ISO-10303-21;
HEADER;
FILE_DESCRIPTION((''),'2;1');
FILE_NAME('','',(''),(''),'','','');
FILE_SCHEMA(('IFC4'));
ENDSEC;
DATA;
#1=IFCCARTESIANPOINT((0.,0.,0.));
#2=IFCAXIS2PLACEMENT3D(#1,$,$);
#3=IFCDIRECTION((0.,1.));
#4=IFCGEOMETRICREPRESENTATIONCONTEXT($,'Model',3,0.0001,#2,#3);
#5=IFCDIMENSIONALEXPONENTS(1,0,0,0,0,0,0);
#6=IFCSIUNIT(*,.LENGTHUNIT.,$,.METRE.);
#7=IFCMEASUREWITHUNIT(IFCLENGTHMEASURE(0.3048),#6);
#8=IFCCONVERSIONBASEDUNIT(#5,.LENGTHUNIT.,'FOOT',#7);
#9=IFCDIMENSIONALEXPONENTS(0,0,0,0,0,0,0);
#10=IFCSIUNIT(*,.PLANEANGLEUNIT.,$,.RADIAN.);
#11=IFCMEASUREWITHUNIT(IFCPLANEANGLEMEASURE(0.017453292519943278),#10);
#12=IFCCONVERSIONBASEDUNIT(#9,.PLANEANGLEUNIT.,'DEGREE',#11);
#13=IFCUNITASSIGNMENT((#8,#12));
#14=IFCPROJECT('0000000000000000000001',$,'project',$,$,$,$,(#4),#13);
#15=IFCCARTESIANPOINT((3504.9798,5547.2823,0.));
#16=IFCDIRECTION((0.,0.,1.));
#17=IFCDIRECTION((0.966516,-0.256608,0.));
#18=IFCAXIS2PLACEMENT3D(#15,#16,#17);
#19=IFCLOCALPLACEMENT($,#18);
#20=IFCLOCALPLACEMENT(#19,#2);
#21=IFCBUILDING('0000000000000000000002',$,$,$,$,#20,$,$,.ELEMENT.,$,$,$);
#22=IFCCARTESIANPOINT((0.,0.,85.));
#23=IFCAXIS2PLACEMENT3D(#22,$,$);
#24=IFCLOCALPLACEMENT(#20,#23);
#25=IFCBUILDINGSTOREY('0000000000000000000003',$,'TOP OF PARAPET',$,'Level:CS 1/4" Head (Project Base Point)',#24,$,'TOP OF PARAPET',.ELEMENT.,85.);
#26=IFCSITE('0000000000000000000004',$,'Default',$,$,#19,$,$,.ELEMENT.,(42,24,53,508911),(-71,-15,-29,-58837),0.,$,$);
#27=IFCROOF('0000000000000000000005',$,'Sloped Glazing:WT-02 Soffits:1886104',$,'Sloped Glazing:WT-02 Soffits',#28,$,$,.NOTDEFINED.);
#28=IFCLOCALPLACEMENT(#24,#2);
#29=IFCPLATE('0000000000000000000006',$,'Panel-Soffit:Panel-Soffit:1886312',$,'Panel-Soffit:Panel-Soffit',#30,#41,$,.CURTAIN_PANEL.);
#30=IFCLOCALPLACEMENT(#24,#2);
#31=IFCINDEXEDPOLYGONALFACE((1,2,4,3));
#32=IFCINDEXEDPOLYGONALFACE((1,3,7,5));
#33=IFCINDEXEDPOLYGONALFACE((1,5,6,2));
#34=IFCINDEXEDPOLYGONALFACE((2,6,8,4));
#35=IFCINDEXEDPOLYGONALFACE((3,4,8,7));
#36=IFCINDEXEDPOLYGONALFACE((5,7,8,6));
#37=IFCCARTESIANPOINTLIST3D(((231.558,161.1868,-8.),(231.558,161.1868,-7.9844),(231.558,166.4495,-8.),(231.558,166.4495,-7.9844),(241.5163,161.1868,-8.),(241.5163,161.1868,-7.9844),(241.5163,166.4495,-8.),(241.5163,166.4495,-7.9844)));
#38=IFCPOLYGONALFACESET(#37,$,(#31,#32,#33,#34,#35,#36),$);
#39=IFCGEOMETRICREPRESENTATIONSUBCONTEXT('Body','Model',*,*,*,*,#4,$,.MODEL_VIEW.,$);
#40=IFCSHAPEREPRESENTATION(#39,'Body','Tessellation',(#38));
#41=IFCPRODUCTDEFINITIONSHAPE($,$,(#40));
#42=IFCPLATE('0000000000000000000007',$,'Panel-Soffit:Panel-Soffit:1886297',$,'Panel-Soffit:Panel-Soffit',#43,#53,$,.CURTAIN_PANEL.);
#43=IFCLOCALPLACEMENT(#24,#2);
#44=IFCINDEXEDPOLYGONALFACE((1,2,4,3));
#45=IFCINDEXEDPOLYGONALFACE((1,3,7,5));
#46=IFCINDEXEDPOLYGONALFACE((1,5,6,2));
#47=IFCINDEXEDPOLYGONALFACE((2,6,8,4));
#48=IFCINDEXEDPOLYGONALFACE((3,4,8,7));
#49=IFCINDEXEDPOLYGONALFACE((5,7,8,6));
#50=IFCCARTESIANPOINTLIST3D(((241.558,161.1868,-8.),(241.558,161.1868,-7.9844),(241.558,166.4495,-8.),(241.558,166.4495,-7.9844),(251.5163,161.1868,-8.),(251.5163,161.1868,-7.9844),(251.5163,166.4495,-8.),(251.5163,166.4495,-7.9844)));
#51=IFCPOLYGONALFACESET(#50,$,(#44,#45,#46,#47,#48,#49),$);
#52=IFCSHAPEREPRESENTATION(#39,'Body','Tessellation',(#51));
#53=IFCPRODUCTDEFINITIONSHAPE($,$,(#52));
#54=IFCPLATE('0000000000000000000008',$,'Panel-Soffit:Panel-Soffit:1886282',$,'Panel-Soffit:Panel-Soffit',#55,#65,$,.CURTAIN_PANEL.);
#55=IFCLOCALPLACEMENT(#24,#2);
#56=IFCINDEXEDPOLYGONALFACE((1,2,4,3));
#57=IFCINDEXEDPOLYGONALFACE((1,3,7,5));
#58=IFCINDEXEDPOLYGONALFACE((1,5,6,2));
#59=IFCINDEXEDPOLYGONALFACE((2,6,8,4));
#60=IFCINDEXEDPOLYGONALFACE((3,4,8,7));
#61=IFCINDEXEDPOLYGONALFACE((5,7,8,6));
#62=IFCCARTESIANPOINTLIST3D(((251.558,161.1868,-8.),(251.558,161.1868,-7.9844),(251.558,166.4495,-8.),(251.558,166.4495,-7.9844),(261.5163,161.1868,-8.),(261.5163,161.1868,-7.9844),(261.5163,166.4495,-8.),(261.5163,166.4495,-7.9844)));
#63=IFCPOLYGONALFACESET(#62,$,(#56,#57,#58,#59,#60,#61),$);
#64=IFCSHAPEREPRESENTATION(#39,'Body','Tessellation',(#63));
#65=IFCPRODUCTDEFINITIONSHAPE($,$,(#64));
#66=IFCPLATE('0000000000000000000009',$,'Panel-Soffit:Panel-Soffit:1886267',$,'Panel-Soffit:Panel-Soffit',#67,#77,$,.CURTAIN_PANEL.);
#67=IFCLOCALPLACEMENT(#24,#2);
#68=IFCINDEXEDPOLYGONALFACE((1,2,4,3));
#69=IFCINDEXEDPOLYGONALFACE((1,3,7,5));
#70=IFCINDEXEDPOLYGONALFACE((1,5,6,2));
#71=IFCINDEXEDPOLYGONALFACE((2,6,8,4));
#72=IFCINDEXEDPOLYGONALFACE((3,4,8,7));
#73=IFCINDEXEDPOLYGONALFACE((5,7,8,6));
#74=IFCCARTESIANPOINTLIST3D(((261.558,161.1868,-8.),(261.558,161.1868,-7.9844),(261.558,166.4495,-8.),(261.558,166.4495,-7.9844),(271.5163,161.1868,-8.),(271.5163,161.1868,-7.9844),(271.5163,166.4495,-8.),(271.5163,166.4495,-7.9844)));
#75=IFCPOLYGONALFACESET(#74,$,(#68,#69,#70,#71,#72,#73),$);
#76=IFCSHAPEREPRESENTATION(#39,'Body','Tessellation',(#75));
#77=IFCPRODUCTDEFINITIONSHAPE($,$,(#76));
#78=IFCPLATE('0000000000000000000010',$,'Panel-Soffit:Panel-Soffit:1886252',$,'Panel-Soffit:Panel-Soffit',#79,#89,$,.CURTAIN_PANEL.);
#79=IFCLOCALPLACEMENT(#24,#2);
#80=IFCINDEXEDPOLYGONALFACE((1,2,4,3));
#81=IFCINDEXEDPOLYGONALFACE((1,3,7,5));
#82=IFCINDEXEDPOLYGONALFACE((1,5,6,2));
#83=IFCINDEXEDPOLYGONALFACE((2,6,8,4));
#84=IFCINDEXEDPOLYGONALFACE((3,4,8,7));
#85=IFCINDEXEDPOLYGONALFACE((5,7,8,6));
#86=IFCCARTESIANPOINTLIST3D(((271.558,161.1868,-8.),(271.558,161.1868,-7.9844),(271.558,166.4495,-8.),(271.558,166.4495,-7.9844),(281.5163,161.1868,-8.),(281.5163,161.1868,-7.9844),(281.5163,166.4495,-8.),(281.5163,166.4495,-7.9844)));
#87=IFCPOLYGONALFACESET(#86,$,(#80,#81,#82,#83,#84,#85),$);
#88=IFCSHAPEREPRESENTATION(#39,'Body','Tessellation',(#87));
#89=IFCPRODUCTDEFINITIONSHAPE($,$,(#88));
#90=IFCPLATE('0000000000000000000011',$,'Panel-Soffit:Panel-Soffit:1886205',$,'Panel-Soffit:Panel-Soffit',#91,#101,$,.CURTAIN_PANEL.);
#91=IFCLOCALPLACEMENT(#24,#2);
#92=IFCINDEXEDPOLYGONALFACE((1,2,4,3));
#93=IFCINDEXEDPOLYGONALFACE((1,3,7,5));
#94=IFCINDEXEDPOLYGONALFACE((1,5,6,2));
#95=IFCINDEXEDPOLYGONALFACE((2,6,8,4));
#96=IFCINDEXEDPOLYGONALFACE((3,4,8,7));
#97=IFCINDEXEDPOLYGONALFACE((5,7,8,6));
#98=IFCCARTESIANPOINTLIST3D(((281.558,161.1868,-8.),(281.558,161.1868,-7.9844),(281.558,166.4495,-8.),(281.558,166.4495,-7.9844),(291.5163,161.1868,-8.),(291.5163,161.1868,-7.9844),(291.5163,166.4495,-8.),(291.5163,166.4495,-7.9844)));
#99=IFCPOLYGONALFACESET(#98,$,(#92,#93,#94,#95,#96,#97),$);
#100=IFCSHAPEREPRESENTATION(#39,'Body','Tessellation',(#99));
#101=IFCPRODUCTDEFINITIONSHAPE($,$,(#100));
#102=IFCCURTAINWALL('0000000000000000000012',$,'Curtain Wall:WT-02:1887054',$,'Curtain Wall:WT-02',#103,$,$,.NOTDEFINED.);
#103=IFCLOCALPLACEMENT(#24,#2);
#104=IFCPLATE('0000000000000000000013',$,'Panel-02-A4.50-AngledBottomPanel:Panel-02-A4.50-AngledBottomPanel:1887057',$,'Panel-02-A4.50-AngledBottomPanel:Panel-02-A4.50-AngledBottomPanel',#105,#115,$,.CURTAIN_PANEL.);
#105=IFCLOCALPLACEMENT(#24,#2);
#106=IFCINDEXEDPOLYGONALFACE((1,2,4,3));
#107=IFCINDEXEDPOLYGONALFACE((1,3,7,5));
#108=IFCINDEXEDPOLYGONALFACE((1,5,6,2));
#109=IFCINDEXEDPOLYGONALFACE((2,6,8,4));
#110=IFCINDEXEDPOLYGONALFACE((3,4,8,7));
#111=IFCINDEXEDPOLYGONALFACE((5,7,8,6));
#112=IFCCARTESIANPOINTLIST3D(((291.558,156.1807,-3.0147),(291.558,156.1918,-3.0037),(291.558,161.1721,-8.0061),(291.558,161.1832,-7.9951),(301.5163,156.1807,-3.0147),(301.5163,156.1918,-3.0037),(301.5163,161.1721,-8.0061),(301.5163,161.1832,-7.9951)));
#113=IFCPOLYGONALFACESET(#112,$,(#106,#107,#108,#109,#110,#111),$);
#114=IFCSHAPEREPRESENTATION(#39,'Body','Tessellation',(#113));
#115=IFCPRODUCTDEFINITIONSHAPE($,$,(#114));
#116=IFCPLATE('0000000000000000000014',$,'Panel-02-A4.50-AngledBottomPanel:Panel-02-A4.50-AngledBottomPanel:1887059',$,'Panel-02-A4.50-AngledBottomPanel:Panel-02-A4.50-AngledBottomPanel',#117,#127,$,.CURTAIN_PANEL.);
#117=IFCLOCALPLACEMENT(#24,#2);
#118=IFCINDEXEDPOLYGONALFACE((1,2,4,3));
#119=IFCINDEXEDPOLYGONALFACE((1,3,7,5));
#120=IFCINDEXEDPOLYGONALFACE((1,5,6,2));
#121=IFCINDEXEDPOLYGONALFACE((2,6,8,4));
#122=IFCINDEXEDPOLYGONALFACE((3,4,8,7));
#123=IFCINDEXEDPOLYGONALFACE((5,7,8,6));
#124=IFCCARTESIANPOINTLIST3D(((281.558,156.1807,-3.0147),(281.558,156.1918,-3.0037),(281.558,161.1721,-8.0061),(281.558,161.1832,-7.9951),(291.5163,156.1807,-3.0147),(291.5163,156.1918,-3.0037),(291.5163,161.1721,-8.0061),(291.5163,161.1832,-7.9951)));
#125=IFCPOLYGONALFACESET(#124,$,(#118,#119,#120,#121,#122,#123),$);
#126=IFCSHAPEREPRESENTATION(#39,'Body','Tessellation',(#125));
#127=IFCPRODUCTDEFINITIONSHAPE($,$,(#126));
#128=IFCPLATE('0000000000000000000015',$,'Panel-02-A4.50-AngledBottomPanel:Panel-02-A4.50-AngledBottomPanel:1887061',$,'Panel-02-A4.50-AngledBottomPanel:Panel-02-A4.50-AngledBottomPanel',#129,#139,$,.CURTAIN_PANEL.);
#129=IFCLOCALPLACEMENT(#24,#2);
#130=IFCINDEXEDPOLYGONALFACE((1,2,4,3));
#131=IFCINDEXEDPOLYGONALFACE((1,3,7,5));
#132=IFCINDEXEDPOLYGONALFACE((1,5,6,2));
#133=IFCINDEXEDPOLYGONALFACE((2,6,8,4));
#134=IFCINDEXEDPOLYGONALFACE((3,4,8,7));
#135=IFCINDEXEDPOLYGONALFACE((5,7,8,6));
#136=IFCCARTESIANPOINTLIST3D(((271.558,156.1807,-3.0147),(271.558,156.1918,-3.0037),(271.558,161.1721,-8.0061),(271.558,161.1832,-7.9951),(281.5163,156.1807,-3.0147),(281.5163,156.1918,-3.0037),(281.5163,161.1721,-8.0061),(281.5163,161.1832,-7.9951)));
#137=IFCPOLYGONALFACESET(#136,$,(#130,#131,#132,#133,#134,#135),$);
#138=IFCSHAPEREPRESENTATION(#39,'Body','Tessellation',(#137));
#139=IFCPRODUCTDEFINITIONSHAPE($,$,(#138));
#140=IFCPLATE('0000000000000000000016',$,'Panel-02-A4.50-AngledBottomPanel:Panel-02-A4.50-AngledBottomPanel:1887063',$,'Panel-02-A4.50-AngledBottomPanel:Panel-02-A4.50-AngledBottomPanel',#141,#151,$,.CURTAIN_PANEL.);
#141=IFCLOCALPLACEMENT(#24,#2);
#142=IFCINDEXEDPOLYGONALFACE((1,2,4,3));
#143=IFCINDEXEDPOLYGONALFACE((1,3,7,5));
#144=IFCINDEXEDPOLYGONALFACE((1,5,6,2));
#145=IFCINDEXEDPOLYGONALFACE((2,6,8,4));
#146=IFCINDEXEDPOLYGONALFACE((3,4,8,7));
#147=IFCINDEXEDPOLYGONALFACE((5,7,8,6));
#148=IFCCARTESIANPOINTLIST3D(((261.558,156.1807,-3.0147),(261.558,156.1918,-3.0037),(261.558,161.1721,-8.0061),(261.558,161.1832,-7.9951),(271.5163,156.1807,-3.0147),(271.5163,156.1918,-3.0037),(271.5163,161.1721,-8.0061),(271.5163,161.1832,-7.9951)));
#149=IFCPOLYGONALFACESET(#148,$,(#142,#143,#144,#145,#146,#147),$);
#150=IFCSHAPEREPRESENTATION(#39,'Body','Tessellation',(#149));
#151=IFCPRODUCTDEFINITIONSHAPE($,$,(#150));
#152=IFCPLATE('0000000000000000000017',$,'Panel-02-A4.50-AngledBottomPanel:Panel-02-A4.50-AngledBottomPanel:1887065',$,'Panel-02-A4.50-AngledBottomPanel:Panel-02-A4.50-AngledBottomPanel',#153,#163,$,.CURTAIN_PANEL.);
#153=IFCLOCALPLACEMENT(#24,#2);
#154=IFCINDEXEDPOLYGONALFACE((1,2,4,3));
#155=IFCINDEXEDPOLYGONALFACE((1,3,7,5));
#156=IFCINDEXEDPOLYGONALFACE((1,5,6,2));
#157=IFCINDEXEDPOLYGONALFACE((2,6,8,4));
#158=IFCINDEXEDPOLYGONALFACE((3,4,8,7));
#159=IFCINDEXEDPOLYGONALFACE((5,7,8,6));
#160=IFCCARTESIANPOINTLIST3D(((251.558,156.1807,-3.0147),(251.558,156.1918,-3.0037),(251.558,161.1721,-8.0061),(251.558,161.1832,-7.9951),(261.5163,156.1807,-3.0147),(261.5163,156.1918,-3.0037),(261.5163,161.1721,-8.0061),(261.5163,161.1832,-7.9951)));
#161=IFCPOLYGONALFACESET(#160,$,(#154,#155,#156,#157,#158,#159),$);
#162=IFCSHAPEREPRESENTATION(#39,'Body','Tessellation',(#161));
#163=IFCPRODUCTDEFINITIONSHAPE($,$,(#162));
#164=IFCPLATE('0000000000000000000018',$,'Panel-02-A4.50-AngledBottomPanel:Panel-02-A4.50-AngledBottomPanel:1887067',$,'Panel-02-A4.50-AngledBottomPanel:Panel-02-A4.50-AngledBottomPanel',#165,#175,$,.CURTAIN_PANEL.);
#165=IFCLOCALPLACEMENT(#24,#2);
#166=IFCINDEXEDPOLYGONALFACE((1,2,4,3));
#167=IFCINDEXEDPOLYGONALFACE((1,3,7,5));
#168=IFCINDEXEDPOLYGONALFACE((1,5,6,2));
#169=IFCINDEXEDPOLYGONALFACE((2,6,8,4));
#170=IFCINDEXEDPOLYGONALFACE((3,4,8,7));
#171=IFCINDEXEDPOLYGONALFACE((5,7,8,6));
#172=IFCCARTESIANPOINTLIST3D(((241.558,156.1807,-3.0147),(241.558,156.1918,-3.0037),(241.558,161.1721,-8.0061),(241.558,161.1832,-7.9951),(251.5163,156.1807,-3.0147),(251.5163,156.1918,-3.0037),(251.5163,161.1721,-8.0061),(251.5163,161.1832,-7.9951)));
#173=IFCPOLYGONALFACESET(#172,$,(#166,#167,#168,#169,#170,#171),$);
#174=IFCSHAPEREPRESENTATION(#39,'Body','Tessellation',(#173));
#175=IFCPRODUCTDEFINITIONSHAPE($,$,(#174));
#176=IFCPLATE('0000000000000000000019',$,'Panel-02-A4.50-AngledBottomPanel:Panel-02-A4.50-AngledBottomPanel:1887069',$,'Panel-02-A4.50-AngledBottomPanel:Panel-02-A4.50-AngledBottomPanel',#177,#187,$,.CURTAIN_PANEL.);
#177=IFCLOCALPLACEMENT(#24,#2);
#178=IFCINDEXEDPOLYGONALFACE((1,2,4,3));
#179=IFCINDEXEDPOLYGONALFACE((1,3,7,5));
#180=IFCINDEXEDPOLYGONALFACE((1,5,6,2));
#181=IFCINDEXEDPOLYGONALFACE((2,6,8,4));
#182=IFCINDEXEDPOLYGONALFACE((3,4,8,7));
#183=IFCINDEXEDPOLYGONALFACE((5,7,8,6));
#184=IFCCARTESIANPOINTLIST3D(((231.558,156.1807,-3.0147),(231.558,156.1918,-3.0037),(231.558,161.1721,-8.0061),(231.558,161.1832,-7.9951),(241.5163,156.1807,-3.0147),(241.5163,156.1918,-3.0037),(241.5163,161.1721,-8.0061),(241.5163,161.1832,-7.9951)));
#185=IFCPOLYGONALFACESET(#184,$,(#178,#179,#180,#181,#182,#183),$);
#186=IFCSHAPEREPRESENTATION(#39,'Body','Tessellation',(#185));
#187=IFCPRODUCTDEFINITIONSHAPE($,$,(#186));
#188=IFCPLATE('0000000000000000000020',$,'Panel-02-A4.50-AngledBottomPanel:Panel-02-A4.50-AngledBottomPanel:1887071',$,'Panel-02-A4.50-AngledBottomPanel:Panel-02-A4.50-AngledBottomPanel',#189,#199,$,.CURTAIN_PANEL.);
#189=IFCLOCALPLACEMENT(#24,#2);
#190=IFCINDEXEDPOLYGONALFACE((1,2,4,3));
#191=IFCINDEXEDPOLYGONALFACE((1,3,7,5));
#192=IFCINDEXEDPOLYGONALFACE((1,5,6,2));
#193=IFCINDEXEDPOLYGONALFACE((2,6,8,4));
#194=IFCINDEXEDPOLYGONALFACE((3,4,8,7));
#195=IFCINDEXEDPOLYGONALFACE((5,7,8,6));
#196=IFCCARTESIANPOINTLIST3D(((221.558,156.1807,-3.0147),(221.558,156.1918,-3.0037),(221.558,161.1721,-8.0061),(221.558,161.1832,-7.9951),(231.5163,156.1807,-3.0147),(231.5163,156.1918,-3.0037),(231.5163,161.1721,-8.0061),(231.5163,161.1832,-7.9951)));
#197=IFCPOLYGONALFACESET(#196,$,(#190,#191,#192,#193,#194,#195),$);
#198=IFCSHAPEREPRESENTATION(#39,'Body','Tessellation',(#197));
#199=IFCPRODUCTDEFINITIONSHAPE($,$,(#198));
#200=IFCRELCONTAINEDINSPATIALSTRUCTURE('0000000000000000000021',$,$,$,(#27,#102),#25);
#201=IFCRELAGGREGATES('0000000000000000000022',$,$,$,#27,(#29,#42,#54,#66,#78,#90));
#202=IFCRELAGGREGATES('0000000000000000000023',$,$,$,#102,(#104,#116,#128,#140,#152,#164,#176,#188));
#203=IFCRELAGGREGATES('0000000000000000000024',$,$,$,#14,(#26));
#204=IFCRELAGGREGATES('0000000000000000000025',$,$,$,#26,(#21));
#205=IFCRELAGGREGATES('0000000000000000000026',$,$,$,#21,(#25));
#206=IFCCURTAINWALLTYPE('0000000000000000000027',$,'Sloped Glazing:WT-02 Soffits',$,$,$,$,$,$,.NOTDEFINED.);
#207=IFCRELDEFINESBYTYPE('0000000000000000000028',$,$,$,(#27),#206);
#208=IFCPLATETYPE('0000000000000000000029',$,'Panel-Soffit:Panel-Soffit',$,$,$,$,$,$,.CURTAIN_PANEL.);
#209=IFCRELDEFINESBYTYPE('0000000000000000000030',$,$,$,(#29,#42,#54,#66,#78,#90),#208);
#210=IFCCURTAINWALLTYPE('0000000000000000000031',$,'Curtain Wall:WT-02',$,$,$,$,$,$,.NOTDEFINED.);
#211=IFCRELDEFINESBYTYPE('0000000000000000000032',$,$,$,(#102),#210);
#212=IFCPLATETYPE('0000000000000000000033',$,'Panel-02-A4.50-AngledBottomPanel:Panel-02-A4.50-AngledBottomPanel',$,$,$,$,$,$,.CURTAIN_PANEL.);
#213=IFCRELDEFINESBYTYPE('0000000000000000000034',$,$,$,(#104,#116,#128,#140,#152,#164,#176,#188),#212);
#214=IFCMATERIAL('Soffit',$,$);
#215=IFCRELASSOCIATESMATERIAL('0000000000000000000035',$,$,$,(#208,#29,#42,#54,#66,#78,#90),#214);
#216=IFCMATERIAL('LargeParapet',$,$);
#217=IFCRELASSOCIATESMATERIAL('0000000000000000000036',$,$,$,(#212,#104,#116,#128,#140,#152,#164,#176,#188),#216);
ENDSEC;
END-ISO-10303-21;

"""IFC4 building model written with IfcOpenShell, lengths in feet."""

from ifc_helpers import new_model, entity, si_unit, converted_unit, direction, frame, origin, place, context, subcontext, project, spatial, indexed_curve, outline, extrude, source, transform, mapped, material, type_object, type_shapes, element, aggregate, save


model = new_model("IFC4")

# Units and contexts
model_context = context("Model", 3, precision=0.0001, world=origin(), true_north=direction((0.0, 1.0)))
body_context = subcontext(model_context, "Body", "Model", "MODEL_VIEW")
ifc_project = project(units=[converted_unit("LENGTHUNIT", "FOOT", entity("IfcLengthMeasure", 0.3048), si_unit("LENGTHUNIT", "METRE"), dimensions=[1, 0, 0, 0, 0, 0, 0]), converted_unit("PLANEANGLEUNIT", "DEGREE", entity("IfcPlaneAngleMeasure", 0.017453292519943278), si_unit("PLANEANGLEUNIT", "RADIAN"), dimensions=[0, 0, 0, 0, 0, 0, 0])], contexts=[model_context])

# Site, building, storey
site_placement = place(None, frame((3504.9798, 5547.2823, 0.0), z_axis=(0.0, 0.0, 1.0), x_axis=(0.966516, -0.256608, 0.0)))
site = spatial("IfcSite", under=ifc_project, at=site_placement, Name="Default", CompositionType="ELEMENT", RefLatitude=(42, 24, 53, 508911), RefLongitude=(-71, -15, -29, -58837), RefElevation=0.0)
building_placement = place(site_placement, origin())
building = spatial("IfcBuilding", under=site, at=building_placement, CompositionType="ELEMENT")
storey_placement = place(building_placement, frame((0.0, 0.0, 85.0)))
storey = spatial("IfcBuildingStorey", under=building, at=storey_placement, Name="TOP OF PARAPET", ObjectType="Level:CS 1/4\" Head (Project Base Point)", LongName="TOP OF PARAPET", CompositionType="ELEMENT", Elevation=85.0)

# Shared definitions
curtain_wall_type_1 = type_object("IfcCurtainWallType", Name="Curtain Wall:WT-02", PredefinedType="NOTDEFINED")
ifc_material_1 = material(Name="LargeParapet")

# Roof, plates
curtain_wall_type_2 = type_object("IfcCurtainWallType", Name="Sloped Glazing:WT-02 Soffits", PredefinedType="NOTDEFINED")
roof_placement = place(storey_placement, frame((0.0, 0.0, -85.0)))
roof = element("IfcRoof", 1, at=roof_placement, inside=storey, type_object=curtain_wall_type_2, Name="Sloped Glazing:WT-02 Soffits:1886104", ObjectType="Sloped Glazing:WT-02 Soffits", PredefinedType="NOTDEFINED")
ifc_material_2 = material(Name="Soffit")
plate_type_1 = type_object("IfcPlateType", Name="Panel-Soffit:Panel-Soffit", PredefinedType="CURTAIN_PANEL", material=ifc_material_2)
shared_shape_1 = source(origin(), body_context, "Body", "SweptSolid", [
    extrude(outline(indexed_curve([(-0.0078, -4.9792), (0.0078, -4.9792), (0.0078, 4.9792), (-0.0078, 4.9792), (-0.0078, -4.9792)], self_intersect=False)), frame((0.0, -0.0078, 0.0208), z_axis=(0.0, 0.0, 1.0), x_axis=(0.0, -1.0, 0.0)), (0.0, 0.0, 1.0), 5.2626),
])
type_shapes(plate_type_1, [shared_shape_1])
plate_1_placement = place(roof_placement, frame((236.5372, 161.166, 77.0), z_axis=(0.0, 1.0, 0.0), x_axis=(1.0, 0.0, 0.0)))
plate_1 = element("IfcPlate", 2, at=plate_1_placement, type_object=plate_type_1, material=ifc_material_2, Name="Panel-Soffit:Panel-Soffit:1886312", ObjectType="Panel-Soffit:Panel-Soffit", PredefinedType="CURTAIN_PANEL", context=body_context, shape_type="MappedRepresentation", body=[
    mapped(shared_shape_1, transform((0.0, 0.0, 0.0), scale=1.0)),
])
plate_2_placement = place(roof_placement, frame((246.5372, 161.166, 77.0), z_axis=(0.0, 1.0, 0.0), x_axis=(1.0, 0.0, 0.0)))
plate_2 = element("IfcPlate", 3, at=plate_2_placement, type_object=plate_type_1, material=ifc_material_2, Name="Panel-Soffit:Panel-Soffit:1886297", ObjectType="Panel-Soffit:Panel-Soffit", PredefinedType="CURTAIN_PANEL", context=body_context, shape_type="MappedRepresentation", body=[
    mapped(shared_shape_1, transform((0.0, 0.0, 0.0), scale=1.0)),
])
plate_3_placement = place(roof_placement, frame((256.5372, 161.166, 77.0), z_axis=(0.0, 1.0, 0.0), x_axis=(1.0, 0.0, 0.0)))
plate_3 = element("IfcPlate", 4, at=plate_3_placement, type_object=plate_type_1, material=ifc_material_2, Name="Panel-Soffit:Panel-Soffit:1886282", ObjectType="Panel-Soffit:Panel-Soffit", PredefinedType="CURTAIN_PANEL", context=body_context, shape_type="MappedRepresentation", body=[
    mapped(shared_shape_1, transform((0.0, 0.0, 0.0), scale=1.0)),
])
plate_4_placement = place(roof_placement, frame((266.5372, 161.166, 77.0), z_axis=(0.0, 1.0, 0.0), x_axis=(1.0, 0.0, 0.0)))
plate_4 = element("IfcPlate", 5, at=plate_4_placement, type_object=plate_type_1, material=ifc_material_2, Name="Panel-Soffit:Panel-Soffit:1886267", ObjectType="Panel-Soffit:Panel-Soffit", PredefinedType="CURTAIN_PANEL", context=body_context, shape_type="MappedRepresentation", body=[
    mapped(shared_shape_1, transform((0.0, 0.0, 0.0), scale=1.0)),
])
plate_5_placement = place(roof_placement, frame((276.5372, 161.166, 77.0), z_axis=(0.0, 1.0, 0.0), x_axis=(1.0, 0.0, 0.0)))
plate_5 = element("IfcPlate", 6, at=plate_5_placement, type_object=plate_type_1, material=ifc_material_2, Name="Panel-Soffit:Panel-Soffit:1886252", ObjectType="Panel-Soffit:Panel-Soffit", PredefinedType="CURTAIN_PANEL", context=body_context, shape_type="MappedRepresentation", body=[
    mapped(shared_shape_1, transform((0.0, 0.0, 0.0), scale=1.0)),
])
plate_6_placement = place(roof_placement, frame((286.5372, 161.166, 77.0), z_axis=(0.0, 1.0, 0.0), x_axis=(1.0, 0.0, 0.0)))
plate_6 = element("IfcPlate", 7, at=plate_6_placement, type_object=plate_type_1, material=ifc_material_2, Name="Panel-Soffit:Panel-Soffit:1886205", ObjectType="Panel-Soffit:Panel-Soffit", PredefinedType="CURTAIN_PANEL", context=body_context, shape_type="MappedRepresentation", body=[
    mapped(shared_shape_1, transform((0.0, 0.0, 0.0), scale=1.0)),
])
aggregate(roof, [plate_1, plate_2, plate_3, plate_4, plate_5, plate_6])

# Curtain wall, plates
curtain_wall_1_placement = place(storey_placement, frame((0.0, 0.0, -85.0)))
curtain_wall_1 = element("IfcCurtainWall", 8, at=curtain_wall_1_placement, inside=storey, type_object=curtain_wall_type_1, Name="Curtain Wall:WT-02:1887054", ObjectType="Curtain Wall:WT-02", PredefinedType="NOTDEFINED")
plate_type_2 = type_object("IfcPlateType", Name="Panel-02-A4.50-AngledBottomPanel:Panel-02-A4.50-AngledBottomPanel", PredefinedType="CURTAIN_PANEL", material=ifc_material_1)
shared_shape_2 = source(origin(), body_context, "Body", "SweptSolid", [
    extrude(outline(indexed_curve([(-0.0078, -4.9792), (0.0078, -4.9792), (0.0078, 4.9792), (-0.0078, 4.9792), (-0.0078, -4.9792)], self_intersect=False)), frame((0.0, -0.0078, 0.0208), z_axis=(0.0, 0.0, 1.0), x_axis=(0.0, -1.0, 0.0)), (0.0, 0.0, 1.0), 7.0589),
])
type_shapes(plate_type_2, [shared_shape_2])
plate_7_placement = place(curtain_wall_1_placement, frame((296.5372, 161.1868, 76.9792), z_axis=(0.0, -0.707107, 0.707107), x_axis=(-1.0, 0.0, 0.0)))
plate_7 = element("IfcPlate", 9, at=plate_7_placement, type_object=plate_type_2, material=ifc_material_1, Name="Panel-02-A4.50-AngledBottomPanel:Panel-02-A4.50-AngledBottomPanel:1887057", ObjectType="Panel-02-A4.50-AngledBottomPanel:Panel-02-A4.50-AngledBottomPanel", PredefinedType="CURTAIN_PANEL", context=body_context, shape_type="MappedRepresentation", body=[
    mapped(shared_shape_2, transform((0.0, 0.0, 0.0), scale=1.0)),
])
plate_8_placement = place(curtain_wall_1_placement, frame((286.5372, 161.1868, 76.9792), z_axis=(0.0, -0.707107, 0.707107), x_axis=(-1.0, 0.0, 0.0)))
plate_8 = element("IfcPlate", 10, at=plate_8_placement, type_object=plate_type_2, material=ifc_material_1, Name="Panel-02-A4.50-AngledBottomPanel:Panel-02-A4.50-AngledBottomPanel:1887059", ObjectType="Panel-02-A4.50-AngledBottomPanel:Panel-02-A4.50-AngledBottomPanel", PredefinedType="CURTAIN_PANEL", context=body_context, shape_type="MappedRepresentation", body=[
    mapped(shared_shape_2, transform((0.0, 0.0, 0.0), scale=1.0)),
])
plate_9_placement = place(curtain_wall_1_placement, frame((276.5372, 161.1868, 76.9792), z_axis=(0.0, -0.707107, 0.707107), x_axis=(-1.0, 0.0, 0.0)))
plate_9 = element("IfcPlate", 11, at=plate_9_placement, type_object=plate_type_2, material=ifc_material_1, Name="Panel-02-A4.50-AngledBottomPanel:Panel-02-A4.50-AngledBottomPanel:1887061", ObjectType="Panel-02-A4.50-AngledBottomPanel:Panel-02-A4.50-AngledBottomPanel", PredefinedType="CURTAIN_PANEL", context=body_context, shape_type="MappedRepresentation", body=[
    mapped(shared_shape_2, transform((0.0, 0.0, 0.0), scale=1.0)),
])
plate_10_placement = place(curtain_wall_1_placement, frame((266.5372, 161.1868, 76.9792), z_axis=(0.0, -0.707107, 0.707107), x_axis=(-1.0, 0.0, 0.0)))
plate_10 = element("IfcPlate", 12, at=plate_10_placement, type_object=plate_type_2, material=ifc_material_1, Name="Panel-02-A4.50-AngledBottomPanel:Panel-02-A4.50-AngledBottomPanel:1887063", ObjectType="Panel-02-A4.50-AngledBottomPanel:Panel-02-A4.50-AngledBottomPanel", PredefinedType="CURTAIN_PANEL", context=body_context, shape_type="MappedRepresentation", body=[
    mapped(shared_shape_2, transform((0.0, 0.0, 0.0), scale=1.0)),
])
plate_11_placement = place(curtain_wall_1_placement, frame((256.5372, 161.1868, 76.9792), z_axis=(0.0, -0.707107, 0.707107), x_axis=(-1.0, 0.0, 0.0)))
plate_11 = element("IfcPlate", 13, at=plate_11_placement, type_object=plate_type_2, material=ifc_material_1, Name="Panel-02-A4.50-AngledBottomPanel:Panel-02-A4.50-AngledBottomPanel:1887065", ObjectType="Panel-02-A4.50-AngledBottomPanel:Panel-02-A4.50-AngledBottomPanel", PredefinedType="CURTAIN_PANEL", context=body_context, shape_type="MappedRepresentation", body=[
    mapped(shared_shape_2, transform((0.0, 0.0, 0.0), scale=1.0)),
])
plate_12_placement = place(curtain_wall_1_placement, frame((246.5372, 161.1868, 76.9792), z_axis=(0.0, -0.707107, 0.707107), x_axis=(-1.0, 0.0, 0.0)))
plate_12 = element("IfcPlate", 14, at=plate_12_placement, type_object=plate_type_2, material=ifc_material_1, Name="Panel-02-A4.50-AngledBottomPanel:Panel-02-A4.50-AngledBottomPanel:1887067", ObjectType="Panel-02-A4.50-AngledBottomPanel:Panel-02-A4.50-AngledBottomPanel", PredefinedType="CURTAIN_PANEL", context=body_context, shape_type="MappedRepresentation", body=[
    mapped(shared_shape_2, transform((0.0, 0.0, 0.0), scale=1.0)),
])
plate_13_placement = place(curtain_wall_1_placement, frame((236.5372, 161.1868, 76.9792), z_axis=(0.0, -0.707107, 0.707107), x_axis=(-1.0, 0.0, 0.0)))
plate_13 = element("IfcPlate", 15, at=plate_13_placement, type_object=plate_type_2, material=ifc_material_1, Name="Panel-02-A4.50-AngledBottomPanel:Panel-02-A4.50-AngledBottomPanel:1887069", ObjectType="Panel-02-A4.50-AngledBottomPanel:Panel-02-A4.50-AngledBottomPanel", PredefinedType="CURTAIN_PANEL", context=body_context, shape_type="MappedRepresentation", body=[
    mapped(shared_shape_2, transform((0.0, 0.0, 0.0), scale=1.0)),
])
plate_14_placement = place(curtain_wall_1_placement, frame((226.5372, 161.1868, 76.9792), z_axis=(0.0, -0.707107, 0.707107), x_axis=(-1.0, 0.0, 0.0)))
plate_14 = element("IfcPlate", 16, at=plate_14_placement, type_object=plate_type_2, material=ifc_material_1, Name="Panel-02-A4.50-AngledBottomPanel:Panel-02-A4.50-AngledBottomPanel:1887071", ObjectType="Panel-02-A4.50-AngledBottomPanel:Panel-02-A4.50-AngledBottomPanel", PredefinedType="CURTAIN_PANEL", context=body_context, shape_type="MappedRepresentation", body=[
    mapped(shared_shape_2, transform((0.0, 0.0, 0.0), scale=1.0)),
])
aggregate(curtain_wall_1, [plate_7, plate_8, plate_9, plate_10, plate_11, plate_12, plate_13, plate_14])

save(model, "model.ifc")
